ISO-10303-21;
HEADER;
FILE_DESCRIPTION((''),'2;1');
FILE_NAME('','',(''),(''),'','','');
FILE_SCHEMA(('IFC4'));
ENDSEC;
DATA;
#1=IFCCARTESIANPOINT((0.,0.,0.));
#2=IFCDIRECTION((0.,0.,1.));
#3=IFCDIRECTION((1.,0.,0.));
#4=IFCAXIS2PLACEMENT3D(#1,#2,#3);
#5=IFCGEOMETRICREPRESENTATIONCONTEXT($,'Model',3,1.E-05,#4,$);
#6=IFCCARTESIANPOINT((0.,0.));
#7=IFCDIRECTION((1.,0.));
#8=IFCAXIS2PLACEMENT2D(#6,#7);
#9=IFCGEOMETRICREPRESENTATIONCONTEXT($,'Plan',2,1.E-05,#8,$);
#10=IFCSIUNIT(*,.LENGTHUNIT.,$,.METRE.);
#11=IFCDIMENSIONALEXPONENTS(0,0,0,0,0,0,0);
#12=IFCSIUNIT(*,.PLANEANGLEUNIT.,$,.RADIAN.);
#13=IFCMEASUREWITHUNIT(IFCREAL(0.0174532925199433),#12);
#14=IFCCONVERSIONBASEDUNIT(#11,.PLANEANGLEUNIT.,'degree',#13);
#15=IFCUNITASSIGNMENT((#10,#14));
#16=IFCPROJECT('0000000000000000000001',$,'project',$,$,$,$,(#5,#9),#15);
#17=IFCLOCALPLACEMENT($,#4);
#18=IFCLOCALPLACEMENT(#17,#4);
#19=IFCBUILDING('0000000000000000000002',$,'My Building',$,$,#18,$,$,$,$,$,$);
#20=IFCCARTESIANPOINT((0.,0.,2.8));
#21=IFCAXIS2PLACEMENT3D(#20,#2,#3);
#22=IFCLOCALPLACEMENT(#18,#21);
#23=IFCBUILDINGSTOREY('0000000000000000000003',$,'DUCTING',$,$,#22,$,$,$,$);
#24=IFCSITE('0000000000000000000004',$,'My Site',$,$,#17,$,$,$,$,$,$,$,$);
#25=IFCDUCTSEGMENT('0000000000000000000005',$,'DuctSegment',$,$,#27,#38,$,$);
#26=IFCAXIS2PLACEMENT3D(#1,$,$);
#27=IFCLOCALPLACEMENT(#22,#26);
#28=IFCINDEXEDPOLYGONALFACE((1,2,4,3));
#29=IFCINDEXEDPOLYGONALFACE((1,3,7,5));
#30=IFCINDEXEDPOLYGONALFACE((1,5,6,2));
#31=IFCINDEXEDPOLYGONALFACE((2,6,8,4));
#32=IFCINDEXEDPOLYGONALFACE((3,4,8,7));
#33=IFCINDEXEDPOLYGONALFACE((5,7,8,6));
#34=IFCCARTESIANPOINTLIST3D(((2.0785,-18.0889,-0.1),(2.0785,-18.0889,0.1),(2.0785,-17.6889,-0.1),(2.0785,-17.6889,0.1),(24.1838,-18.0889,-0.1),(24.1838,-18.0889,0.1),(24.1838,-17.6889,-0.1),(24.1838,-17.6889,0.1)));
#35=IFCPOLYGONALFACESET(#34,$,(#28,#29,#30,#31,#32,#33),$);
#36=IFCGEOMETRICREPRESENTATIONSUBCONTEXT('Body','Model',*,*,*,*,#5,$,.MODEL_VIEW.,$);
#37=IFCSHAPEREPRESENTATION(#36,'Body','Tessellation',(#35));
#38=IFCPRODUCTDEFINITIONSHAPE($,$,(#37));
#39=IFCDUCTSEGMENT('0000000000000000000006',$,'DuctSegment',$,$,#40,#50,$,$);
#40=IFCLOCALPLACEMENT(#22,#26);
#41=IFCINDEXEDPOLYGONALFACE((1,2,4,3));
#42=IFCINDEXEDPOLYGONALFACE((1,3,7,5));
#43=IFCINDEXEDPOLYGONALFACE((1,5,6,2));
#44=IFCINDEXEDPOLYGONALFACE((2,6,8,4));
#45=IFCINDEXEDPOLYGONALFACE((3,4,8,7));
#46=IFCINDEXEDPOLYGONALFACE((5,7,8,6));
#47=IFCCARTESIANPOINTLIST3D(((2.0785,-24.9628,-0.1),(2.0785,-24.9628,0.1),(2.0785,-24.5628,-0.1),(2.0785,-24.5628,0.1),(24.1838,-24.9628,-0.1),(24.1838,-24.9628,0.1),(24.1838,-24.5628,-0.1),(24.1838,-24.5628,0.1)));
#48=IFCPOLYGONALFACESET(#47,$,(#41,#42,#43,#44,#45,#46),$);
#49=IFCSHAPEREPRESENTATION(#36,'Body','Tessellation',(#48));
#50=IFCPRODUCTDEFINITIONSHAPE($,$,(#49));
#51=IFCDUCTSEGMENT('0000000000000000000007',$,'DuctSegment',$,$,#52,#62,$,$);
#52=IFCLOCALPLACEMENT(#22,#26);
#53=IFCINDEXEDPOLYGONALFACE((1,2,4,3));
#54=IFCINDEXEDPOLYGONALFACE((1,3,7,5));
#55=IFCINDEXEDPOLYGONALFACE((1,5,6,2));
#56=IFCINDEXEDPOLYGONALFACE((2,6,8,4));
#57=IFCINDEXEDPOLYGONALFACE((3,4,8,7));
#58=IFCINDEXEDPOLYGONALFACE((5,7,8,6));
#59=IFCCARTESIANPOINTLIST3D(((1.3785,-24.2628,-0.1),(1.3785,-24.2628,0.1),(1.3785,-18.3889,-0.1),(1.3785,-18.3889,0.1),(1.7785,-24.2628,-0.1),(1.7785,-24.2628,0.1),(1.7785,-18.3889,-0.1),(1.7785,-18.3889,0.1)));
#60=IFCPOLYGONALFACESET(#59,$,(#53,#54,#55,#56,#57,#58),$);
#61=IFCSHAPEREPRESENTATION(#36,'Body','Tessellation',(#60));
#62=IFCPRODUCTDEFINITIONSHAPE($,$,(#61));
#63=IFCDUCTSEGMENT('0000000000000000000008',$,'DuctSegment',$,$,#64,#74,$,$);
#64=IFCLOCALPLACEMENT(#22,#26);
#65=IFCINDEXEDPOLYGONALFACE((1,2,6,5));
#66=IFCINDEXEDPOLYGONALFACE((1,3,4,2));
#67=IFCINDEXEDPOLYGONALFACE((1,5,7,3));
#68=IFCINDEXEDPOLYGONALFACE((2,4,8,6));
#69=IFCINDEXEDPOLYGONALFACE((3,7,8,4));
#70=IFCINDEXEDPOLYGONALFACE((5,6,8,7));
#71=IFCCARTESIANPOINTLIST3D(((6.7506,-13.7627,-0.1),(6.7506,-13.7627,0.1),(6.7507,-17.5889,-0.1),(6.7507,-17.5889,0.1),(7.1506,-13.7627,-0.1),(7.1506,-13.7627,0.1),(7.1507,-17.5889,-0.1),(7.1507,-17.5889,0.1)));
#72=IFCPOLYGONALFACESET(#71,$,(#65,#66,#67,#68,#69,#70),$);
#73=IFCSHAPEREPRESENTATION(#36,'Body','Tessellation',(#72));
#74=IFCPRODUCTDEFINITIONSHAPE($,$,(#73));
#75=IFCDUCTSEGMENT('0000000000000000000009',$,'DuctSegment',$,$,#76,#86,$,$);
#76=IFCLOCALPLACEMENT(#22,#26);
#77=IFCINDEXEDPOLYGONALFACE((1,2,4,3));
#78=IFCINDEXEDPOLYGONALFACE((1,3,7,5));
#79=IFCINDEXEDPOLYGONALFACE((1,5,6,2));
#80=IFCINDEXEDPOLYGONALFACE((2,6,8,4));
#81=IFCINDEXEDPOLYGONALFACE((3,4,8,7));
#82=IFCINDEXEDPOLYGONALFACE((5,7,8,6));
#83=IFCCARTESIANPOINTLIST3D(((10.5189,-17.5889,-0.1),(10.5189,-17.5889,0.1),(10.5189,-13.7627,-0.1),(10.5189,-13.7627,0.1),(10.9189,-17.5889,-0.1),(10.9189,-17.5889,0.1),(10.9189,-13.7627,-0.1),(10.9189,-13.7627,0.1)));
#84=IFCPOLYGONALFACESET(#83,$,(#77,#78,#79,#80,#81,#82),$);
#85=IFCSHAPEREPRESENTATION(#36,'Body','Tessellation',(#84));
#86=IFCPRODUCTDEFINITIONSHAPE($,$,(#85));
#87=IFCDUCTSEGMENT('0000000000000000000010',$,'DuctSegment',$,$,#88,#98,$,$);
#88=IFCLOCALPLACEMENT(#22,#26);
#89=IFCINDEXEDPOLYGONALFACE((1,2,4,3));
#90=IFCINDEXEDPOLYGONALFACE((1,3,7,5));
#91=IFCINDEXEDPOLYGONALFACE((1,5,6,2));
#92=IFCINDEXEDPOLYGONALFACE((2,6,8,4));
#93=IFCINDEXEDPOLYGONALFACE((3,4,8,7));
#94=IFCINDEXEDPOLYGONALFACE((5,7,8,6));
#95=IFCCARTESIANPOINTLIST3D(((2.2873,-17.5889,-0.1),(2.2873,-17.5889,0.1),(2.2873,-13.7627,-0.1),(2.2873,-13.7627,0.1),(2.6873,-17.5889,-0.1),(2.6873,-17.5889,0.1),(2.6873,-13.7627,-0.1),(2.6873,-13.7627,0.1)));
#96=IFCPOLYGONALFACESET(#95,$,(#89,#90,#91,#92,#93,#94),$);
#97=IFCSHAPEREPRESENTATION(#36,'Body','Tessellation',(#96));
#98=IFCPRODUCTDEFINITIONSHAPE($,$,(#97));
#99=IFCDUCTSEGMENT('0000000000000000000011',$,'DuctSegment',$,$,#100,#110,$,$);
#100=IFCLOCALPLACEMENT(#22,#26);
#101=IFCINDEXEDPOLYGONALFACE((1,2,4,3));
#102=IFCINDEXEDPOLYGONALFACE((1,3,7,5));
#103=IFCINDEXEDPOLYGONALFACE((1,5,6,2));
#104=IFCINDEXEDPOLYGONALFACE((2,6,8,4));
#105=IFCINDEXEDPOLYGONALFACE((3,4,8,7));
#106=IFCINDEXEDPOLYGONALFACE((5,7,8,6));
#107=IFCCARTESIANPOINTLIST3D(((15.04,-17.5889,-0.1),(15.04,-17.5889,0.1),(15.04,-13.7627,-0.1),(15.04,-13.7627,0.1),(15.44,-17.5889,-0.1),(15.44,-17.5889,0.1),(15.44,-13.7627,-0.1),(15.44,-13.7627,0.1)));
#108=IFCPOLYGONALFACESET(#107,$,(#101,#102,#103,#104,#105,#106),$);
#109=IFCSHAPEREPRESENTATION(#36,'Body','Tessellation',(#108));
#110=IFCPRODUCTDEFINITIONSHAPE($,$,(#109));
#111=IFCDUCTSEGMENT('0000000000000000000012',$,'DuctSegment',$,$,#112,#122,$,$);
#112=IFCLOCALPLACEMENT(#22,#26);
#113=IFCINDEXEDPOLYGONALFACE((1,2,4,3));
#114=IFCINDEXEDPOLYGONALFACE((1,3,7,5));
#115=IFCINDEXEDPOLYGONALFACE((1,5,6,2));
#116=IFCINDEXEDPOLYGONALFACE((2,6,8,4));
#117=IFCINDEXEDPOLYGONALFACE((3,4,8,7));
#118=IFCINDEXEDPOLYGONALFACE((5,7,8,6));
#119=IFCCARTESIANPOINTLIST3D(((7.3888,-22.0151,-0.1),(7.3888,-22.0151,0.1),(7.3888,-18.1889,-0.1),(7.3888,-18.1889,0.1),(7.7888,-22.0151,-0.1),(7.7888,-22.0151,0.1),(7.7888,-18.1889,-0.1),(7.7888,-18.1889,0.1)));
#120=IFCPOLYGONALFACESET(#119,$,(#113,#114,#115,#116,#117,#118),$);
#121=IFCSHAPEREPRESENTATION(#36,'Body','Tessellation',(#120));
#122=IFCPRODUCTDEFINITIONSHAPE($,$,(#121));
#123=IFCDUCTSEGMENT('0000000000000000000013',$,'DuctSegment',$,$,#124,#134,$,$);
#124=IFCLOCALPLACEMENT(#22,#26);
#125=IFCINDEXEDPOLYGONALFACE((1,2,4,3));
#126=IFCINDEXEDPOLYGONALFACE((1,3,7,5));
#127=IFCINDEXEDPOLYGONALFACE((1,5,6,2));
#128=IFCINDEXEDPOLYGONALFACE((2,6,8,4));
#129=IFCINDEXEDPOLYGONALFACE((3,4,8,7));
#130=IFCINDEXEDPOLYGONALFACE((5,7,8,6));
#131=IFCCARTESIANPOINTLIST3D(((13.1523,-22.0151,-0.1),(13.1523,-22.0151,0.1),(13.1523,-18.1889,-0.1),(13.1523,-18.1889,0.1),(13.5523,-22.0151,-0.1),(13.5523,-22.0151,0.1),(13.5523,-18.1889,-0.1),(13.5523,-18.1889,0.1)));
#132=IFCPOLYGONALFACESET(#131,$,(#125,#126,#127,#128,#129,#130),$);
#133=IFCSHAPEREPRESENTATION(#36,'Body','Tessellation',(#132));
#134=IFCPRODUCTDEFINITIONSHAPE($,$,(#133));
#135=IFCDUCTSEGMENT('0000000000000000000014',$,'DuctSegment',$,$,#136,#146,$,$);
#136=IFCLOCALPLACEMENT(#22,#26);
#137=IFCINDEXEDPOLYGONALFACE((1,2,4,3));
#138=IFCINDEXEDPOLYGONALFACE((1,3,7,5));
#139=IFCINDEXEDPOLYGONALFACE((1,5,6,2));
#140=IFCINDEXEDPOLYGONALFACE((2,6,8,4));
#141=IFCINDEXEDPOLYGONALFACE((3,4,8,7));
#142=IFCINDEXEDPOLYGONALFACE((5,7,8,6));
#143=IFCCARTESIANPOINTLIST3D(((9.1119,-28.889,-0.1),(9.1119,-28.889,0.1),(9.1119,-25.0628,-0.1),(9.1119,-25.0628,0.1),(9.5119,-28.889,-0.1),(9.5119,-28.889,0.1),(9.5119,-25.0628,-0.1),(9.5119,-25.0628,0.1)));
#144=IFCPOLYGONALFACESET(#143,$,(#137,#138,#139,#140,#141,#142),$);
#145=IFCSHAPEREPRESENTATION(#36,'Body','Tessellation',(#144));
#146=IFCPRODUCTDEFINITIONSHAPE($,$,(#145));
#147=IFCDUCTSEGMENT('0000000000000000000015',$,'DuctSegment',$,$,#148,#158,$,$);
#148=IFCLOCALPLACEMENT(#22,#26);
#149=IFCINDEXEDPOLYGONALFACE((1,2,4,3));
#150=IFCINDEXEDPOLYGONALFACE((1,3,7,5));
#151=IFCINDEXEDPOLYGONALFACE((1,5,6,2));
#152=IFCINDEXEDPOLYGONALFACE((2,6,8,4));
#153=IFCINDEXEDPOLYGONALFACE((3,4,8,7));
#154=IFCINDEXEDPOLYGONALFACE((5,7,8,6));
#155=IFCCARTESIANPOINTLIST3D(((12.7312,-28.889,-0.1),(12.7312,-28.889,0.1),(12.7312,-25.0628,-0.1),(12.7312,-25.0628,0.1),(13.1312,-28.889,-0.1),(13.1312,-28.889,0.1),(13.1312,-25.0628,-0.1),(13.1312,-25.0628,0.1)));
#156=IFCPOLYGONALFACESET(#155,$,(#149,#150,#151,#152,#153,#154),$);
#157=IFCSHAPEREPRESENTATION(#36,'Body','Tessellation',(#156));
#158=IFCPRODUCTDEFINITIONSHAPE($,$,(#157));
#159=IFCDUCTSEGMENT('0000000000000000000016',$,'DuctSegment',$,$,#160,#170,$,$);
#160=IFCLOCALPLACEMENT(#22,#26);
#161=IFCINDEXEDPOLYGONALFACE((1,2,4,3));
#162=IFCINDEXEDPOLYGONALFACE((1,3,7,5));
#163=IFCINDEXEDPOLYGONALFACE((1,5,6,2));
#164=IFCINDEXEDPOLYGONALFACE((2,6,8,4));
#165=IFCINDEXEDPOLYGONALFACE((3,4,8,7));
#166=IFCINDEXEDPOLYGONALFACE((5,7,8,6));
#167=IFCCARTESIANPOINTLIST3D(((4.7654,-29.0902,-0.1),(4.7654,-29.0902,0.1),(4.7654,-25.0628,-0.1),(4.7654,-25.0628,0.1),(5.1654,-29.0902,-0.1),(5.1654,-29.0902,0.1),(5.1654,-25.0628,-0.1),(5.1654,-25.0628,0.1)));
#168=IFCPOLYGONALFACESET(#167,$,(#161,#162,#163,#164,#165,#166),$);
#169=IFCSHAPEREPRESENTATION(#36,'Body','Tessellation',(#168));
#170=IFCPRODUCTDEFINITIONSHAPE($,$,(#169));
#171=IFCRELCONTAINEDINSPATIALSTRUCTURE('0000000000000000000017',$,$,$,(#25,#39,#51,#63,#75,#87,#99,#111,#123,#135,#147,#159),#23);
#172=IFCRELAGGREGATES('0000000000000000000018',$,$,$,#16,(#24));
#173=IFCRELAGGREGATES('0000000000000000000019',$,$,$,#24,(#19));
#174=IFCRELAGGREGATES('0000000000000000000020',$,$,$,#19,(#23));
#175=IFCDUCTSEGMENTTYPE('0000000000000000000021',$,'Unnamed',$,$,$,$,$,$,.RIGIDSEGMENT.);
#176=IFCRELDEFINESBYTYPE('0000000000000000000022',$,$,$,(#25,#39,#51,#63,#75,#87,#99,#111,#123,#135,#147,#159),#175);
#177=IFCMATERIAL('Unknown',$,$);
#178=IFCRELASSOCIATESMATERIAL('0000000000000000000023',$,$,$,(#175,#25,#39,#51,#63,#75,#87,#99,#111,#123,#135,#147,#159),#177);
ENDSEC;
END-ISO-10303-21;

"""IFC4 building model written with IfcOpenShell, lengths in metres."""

from ifc_helpers import new_model, entity, si_unit, converted_unit, frame, origin_with_axes, origin_2d_with_axis, place, context, subcontext, project, spatial, rectangle, extrude, material, material_profile, profile_set, profile_usage, type_object, element, save


model = new_model("IFC4")

# Units and contexts
model_context = context("Model", 3, precision=1e-05, world=origin_with_axes())
plan_context = context("Plan", 2, precision=1e-05, world=origin_2d_with_axis())
body_context = subcontext(model_context, "Body", "Model", "MODEL_VIEW")
ifc_project = project(units=[si_unit("LENGTHUNIT", "METRE"), converted_unit("PLANEANGLEUNIT", "degree", entity("IfcReal", 0.0174532925199433), si_unit("PLANEANGLEUNIT", "RADIAN"), dimensions=[0, 0, 0, 0, 0, 0, 0])], contexts=[model_context, plan_context])

# Site, building, storey
site_placement = place(None, origin_with_axes())
site = spatial("IfcSite", under=ifc_project, at=site_placement, Name="My Site")
building_placement = place(site_placement, origin_with_axes())
building = spatial("IfcBuilding", under=site, at=building_placement, Name="My Building")
storey_placement = place(building_placement, frame((0.0, 0.0, 2.8), z_axis=(0.0, 0.0, 1.0), x_axis=(1.0, 0.0, 0.0)))
storey = spatial("IfcBuildingStorey", under=building, at=storey_placement, Name="DUCTING")

# Duct segments
ifc_material = material(Name="Unknown")
ifc_material_profile_1 = material_profile(ifc_material, rectangle(XDim=0.4, YDim=0.2))
ifc_profile_set_1 = profile_set([ifc_material_profile_1])
ifc_profile_usage_1 = profile_usage(ifc_profile_set_1, cardinal=5)
duct_segment_type = type_object("IfcDuctSegmentType", Name="Unnamed", PredefinedType="RIGIDSEGMENT", material=ifc_profile_set_1)
duct_segment_1_placement = place(storey_placement, frame((2.0785, -17.8889, 0.0), z_axis=(1.0, 0.0, 0.0), x_axis=(0.0, 1.0, 0.0)))
element("IfcDuctSegment", 1, at=duct_segment_1_placement, inside=storey, type_object=duct_segment_type, material=ifc_profile_usage_1, Name="DuctSegment", context=body_context, shape_type="SweptSolid", body=[
    extrude(rectangle(XDim=0.4, YDim=0.2), origin_with_axes(), (0.0, 0.0, 1.0), 22.1052),
])
ifc_profile_usage_2 = profile_usage(ifc_profile_set_1, cardinal=5)
duct_segment_2_placement = place(storey_placement, frame((2.0785, -24.7628, 0.0), z_axis=(1.0, 0.0, 0.0), x_axis=(0.0, 1.0, 0.0)))
element("IfcDuctSegment", 2, at=duct_segment_2_placement, inside=storey, type_object=duct_segment_type, material=ifc_profile_usage_2, Name="DuctSegment", context=body_context, shape_type="SweptSolid", body=[
    extrude(rectangle(XDim=0.4, YDim=0.2), origin_with_axes(), (0.0, 0.0, 1.0), 22.1052),
])
ifc_profile_usage_3 = profile_usage(ifc_profile_set_1, cardinal=5)
duct_segment_3_placement = place(storey_placement, frame((1.5785, -18.3889, 0.0), z_axis=(0.0, -1.0, 0.0), x_axis=(1.0, 0.0, 0.0)))
element("IfcDuctSegment", 3, at=duct_segment_3_placement, inside=storey, type_object=duct_segment_type, material=ifc_profile_usage_3, Name="DuctSegment", context=body_context, shape_type="SweptSolid", body=[
    extrude(rectangle(XDim=0.4, YDim=0.2), origin_with_axes(), (0.0, 0.0, 1.0), 5.8738),
])
ifc_profile_usage_4 = profile_usage(ifc_profile_set_1, cardinal=5)
duct_segment_4_placement = place(storey_placement, frame((6.9507, -17.5889, 0.0), z_axis=(0.0, 1.0, 0.0), x_axis=(-1.0, 0.0, 0.0)))
element("IfcDuctSegment", 4, at=duct_segment_4_placement, inside=storey, type_object=duct_segment_type, material=ifc_profile_usage_4, Name="DuctSegment", context=body_context, shape_type="SweptSolid", body=[
    extrude(rectangle(XDim=0.4, YDim=0.2), origin_with_axes(), (0.0, 0.0, 1.0), 3.8262),
])
ifc_profile_usage_5 = profile_usage(ifc_profile_set_1, cardinal=5)
duct_segment_5_placement = place(storey_placement, frame((10.7189, -17.5889, 0.0), z_axis=(0.0, 1.0, 0.0), x_axis=(-1.0, 0.0, 0.0)))
element("IfcDuctSegment", 5, at=duct_segment_5_placement, inside=storey, type_object=duct_segment_type, material=ifc_profile_usage_5, Name="DuctSegment", context=body_context, shape_type="SweptSolid", body=[
    extrude(rectangle(XDim=0.4, YDim=0.2), origin_with_axes(), (0.0, 0.0, 1.0), 3.8262),
])
ifc_profile_usage_6 = profile_usage(ifc_profile_set_1, cardinal=5)
duct_segment_6_placement = place(storey_placement, frame((2.4873, -17.5889, 0.0), z_axis=(0.0, 1.0, 0.0), x_axis=(-1.0, 0.0, 0.0)))
element("IfcDuctSegment", 6, at=duct_segment_6_placement, inside=storey, type_object=duct_segment_type, material=ifc_profile_usage_6, Name="DuctSegment", context=body_context, shape_type="SweptSolid", body=[
    extrude(rectangle(XDim=0.4, YDim=0.2), origin_with_axes(), (0.0, 0.0, 1.0), 3.8262),
])
ifc_profile_usage_7 = profile_usage(ifc_profile_set_1, cardinal=5)
duct_segment_7_placement = place(storey_placement, frame((15.24, -17.5889, 0.0), z_axis=(0.0, 1.0, 0.0), x_axis=(-1.0, 0.0, 0.0)))
element("IfcDuctSegment", 7, at=duct_segment_7_placement, inside=storey, type_object=duct_segment_type, material=ifc_profile_usage_7, Name="DuctSegment", context=body_context, shape_type="SweptSolid", body=[
    extrude(rectangle(XDim=0.4, YDim=0.2), origin_with_axes(), (0.0, 0.0, 1.0), 3.8262),
])
ifc_profile_usage_8 = profile_usage(ifc_profile_set_1, cardinal=5)
duct_segment_8_placement = place(storey_placement, frame((7.5888, -18.1889, 0.0), z_axis=(0.0, -1.0, 0.0), x_axis=(1.0, 0.0, 0.0)))
element("IfcDuctSegment", 8, at=duct_segment_8_placement, inside=storey, type_object=duct_segment_type, material=ifc_profile_usage_8, Name="DuctSegment", context=body_context, shape_type="SweptSolid", body=[
    extrude(rectangle(XDim=0.4, YDim=0.2), origin_with_axes(), (0.0, 0.0, 1.0), 3.8262),
])
ifc_profile_usage_9 = profile_usage(ifc_profile_set_1, cardinal=5)
duct_segment_9_placement = place(storey_placement, frame((13.3523, -18.1889, 0.0), z_axis=(0.0, -1.0, 0.0), x_axis=(1.0, 0.0, 0.0)))
element("IfcDuctSegment", 9, at=duct_segment_9_placement, inside=storey, type_object=duct_segment_type, material=ifc_profile_usage_9, Name="DuctSegment", context=body_context, shape_type="SweptSolid", body=[
    extrude(rectangle(XDim=0.4, YDim=0.2), origin_with_axes(), (0.0, 0.0, 1.0), 3.8262),
])
ifc_profile_usage_10 = profile_usage(ifc_profile_set_1, cardinal=5)
duct_segment_10_placement = place(storey_placement, frame((9.3119, -25.0628, 0.0), z_axis=(0.0, -1.0, 0.0), x_axis=(1.0, 0.0, 0.0)))
element("IfcDuctSegment", 10, at=duct_segment_10_placement, inside=storey, type_object=duct_segment_type, material=ifc_profile_usage_10, Name="DuctSegment", context=body_context, shape_type="SweptSolid", body=[
    extrude(rectangle(XDim=0.4, YDim=0.2), origin_with_axes(), (0.0, 0.0, 1.0), 3.8262),
])
ifc_profile_usage_11 = profile_usage(ifc_profile_set_1, cardinal=5)
duct_segment_11_placement = place(storey_placement, frame((12.9312, -25.0628, 0.0), z_axis=(0.0, -1.0, 0.0), x_axis=(1.0, 0.0, 0.0)))
element("IfcDuctSegment", 11, at=duct_segment_11_placement, inside=storey, type_object=duct_segment_type, material=ifc_profile_usage_11, Name="DuctSegment", context=body_context, shape_type="SweptSolid", body=[
    extrude(rectangle(XDim=0.4, YDim=0.2), origin_with_axes(), (0.0, 0.0, 1.0), 3.8262),
])
ifc_profile_usage_12 = profile_usage(ifc_profile_set_1, cardinal=5)
duct_segment_12_placement = place(storey_placement, frame((4.9654, -25.0628, 0.0), z_axis=(0.0, -1.0, 0.0), x_axis=(1.0, 0.0, 0.0)))
element("IfcDuctSegment", 12, at=duct_segment_12_placement, inside=storey, type_object=duct_segment_type, material=ifc_profile_usage_12, Name="DuctSegment", context=body_context, shape_type="SweptSolid", body=[
    extrude(rectangle(XDim=0.4, YDim=0.2), origin_with_axes(), (0.0, 0.0, 1.0), 4.0274),
])

save(model, "model.ifc")
